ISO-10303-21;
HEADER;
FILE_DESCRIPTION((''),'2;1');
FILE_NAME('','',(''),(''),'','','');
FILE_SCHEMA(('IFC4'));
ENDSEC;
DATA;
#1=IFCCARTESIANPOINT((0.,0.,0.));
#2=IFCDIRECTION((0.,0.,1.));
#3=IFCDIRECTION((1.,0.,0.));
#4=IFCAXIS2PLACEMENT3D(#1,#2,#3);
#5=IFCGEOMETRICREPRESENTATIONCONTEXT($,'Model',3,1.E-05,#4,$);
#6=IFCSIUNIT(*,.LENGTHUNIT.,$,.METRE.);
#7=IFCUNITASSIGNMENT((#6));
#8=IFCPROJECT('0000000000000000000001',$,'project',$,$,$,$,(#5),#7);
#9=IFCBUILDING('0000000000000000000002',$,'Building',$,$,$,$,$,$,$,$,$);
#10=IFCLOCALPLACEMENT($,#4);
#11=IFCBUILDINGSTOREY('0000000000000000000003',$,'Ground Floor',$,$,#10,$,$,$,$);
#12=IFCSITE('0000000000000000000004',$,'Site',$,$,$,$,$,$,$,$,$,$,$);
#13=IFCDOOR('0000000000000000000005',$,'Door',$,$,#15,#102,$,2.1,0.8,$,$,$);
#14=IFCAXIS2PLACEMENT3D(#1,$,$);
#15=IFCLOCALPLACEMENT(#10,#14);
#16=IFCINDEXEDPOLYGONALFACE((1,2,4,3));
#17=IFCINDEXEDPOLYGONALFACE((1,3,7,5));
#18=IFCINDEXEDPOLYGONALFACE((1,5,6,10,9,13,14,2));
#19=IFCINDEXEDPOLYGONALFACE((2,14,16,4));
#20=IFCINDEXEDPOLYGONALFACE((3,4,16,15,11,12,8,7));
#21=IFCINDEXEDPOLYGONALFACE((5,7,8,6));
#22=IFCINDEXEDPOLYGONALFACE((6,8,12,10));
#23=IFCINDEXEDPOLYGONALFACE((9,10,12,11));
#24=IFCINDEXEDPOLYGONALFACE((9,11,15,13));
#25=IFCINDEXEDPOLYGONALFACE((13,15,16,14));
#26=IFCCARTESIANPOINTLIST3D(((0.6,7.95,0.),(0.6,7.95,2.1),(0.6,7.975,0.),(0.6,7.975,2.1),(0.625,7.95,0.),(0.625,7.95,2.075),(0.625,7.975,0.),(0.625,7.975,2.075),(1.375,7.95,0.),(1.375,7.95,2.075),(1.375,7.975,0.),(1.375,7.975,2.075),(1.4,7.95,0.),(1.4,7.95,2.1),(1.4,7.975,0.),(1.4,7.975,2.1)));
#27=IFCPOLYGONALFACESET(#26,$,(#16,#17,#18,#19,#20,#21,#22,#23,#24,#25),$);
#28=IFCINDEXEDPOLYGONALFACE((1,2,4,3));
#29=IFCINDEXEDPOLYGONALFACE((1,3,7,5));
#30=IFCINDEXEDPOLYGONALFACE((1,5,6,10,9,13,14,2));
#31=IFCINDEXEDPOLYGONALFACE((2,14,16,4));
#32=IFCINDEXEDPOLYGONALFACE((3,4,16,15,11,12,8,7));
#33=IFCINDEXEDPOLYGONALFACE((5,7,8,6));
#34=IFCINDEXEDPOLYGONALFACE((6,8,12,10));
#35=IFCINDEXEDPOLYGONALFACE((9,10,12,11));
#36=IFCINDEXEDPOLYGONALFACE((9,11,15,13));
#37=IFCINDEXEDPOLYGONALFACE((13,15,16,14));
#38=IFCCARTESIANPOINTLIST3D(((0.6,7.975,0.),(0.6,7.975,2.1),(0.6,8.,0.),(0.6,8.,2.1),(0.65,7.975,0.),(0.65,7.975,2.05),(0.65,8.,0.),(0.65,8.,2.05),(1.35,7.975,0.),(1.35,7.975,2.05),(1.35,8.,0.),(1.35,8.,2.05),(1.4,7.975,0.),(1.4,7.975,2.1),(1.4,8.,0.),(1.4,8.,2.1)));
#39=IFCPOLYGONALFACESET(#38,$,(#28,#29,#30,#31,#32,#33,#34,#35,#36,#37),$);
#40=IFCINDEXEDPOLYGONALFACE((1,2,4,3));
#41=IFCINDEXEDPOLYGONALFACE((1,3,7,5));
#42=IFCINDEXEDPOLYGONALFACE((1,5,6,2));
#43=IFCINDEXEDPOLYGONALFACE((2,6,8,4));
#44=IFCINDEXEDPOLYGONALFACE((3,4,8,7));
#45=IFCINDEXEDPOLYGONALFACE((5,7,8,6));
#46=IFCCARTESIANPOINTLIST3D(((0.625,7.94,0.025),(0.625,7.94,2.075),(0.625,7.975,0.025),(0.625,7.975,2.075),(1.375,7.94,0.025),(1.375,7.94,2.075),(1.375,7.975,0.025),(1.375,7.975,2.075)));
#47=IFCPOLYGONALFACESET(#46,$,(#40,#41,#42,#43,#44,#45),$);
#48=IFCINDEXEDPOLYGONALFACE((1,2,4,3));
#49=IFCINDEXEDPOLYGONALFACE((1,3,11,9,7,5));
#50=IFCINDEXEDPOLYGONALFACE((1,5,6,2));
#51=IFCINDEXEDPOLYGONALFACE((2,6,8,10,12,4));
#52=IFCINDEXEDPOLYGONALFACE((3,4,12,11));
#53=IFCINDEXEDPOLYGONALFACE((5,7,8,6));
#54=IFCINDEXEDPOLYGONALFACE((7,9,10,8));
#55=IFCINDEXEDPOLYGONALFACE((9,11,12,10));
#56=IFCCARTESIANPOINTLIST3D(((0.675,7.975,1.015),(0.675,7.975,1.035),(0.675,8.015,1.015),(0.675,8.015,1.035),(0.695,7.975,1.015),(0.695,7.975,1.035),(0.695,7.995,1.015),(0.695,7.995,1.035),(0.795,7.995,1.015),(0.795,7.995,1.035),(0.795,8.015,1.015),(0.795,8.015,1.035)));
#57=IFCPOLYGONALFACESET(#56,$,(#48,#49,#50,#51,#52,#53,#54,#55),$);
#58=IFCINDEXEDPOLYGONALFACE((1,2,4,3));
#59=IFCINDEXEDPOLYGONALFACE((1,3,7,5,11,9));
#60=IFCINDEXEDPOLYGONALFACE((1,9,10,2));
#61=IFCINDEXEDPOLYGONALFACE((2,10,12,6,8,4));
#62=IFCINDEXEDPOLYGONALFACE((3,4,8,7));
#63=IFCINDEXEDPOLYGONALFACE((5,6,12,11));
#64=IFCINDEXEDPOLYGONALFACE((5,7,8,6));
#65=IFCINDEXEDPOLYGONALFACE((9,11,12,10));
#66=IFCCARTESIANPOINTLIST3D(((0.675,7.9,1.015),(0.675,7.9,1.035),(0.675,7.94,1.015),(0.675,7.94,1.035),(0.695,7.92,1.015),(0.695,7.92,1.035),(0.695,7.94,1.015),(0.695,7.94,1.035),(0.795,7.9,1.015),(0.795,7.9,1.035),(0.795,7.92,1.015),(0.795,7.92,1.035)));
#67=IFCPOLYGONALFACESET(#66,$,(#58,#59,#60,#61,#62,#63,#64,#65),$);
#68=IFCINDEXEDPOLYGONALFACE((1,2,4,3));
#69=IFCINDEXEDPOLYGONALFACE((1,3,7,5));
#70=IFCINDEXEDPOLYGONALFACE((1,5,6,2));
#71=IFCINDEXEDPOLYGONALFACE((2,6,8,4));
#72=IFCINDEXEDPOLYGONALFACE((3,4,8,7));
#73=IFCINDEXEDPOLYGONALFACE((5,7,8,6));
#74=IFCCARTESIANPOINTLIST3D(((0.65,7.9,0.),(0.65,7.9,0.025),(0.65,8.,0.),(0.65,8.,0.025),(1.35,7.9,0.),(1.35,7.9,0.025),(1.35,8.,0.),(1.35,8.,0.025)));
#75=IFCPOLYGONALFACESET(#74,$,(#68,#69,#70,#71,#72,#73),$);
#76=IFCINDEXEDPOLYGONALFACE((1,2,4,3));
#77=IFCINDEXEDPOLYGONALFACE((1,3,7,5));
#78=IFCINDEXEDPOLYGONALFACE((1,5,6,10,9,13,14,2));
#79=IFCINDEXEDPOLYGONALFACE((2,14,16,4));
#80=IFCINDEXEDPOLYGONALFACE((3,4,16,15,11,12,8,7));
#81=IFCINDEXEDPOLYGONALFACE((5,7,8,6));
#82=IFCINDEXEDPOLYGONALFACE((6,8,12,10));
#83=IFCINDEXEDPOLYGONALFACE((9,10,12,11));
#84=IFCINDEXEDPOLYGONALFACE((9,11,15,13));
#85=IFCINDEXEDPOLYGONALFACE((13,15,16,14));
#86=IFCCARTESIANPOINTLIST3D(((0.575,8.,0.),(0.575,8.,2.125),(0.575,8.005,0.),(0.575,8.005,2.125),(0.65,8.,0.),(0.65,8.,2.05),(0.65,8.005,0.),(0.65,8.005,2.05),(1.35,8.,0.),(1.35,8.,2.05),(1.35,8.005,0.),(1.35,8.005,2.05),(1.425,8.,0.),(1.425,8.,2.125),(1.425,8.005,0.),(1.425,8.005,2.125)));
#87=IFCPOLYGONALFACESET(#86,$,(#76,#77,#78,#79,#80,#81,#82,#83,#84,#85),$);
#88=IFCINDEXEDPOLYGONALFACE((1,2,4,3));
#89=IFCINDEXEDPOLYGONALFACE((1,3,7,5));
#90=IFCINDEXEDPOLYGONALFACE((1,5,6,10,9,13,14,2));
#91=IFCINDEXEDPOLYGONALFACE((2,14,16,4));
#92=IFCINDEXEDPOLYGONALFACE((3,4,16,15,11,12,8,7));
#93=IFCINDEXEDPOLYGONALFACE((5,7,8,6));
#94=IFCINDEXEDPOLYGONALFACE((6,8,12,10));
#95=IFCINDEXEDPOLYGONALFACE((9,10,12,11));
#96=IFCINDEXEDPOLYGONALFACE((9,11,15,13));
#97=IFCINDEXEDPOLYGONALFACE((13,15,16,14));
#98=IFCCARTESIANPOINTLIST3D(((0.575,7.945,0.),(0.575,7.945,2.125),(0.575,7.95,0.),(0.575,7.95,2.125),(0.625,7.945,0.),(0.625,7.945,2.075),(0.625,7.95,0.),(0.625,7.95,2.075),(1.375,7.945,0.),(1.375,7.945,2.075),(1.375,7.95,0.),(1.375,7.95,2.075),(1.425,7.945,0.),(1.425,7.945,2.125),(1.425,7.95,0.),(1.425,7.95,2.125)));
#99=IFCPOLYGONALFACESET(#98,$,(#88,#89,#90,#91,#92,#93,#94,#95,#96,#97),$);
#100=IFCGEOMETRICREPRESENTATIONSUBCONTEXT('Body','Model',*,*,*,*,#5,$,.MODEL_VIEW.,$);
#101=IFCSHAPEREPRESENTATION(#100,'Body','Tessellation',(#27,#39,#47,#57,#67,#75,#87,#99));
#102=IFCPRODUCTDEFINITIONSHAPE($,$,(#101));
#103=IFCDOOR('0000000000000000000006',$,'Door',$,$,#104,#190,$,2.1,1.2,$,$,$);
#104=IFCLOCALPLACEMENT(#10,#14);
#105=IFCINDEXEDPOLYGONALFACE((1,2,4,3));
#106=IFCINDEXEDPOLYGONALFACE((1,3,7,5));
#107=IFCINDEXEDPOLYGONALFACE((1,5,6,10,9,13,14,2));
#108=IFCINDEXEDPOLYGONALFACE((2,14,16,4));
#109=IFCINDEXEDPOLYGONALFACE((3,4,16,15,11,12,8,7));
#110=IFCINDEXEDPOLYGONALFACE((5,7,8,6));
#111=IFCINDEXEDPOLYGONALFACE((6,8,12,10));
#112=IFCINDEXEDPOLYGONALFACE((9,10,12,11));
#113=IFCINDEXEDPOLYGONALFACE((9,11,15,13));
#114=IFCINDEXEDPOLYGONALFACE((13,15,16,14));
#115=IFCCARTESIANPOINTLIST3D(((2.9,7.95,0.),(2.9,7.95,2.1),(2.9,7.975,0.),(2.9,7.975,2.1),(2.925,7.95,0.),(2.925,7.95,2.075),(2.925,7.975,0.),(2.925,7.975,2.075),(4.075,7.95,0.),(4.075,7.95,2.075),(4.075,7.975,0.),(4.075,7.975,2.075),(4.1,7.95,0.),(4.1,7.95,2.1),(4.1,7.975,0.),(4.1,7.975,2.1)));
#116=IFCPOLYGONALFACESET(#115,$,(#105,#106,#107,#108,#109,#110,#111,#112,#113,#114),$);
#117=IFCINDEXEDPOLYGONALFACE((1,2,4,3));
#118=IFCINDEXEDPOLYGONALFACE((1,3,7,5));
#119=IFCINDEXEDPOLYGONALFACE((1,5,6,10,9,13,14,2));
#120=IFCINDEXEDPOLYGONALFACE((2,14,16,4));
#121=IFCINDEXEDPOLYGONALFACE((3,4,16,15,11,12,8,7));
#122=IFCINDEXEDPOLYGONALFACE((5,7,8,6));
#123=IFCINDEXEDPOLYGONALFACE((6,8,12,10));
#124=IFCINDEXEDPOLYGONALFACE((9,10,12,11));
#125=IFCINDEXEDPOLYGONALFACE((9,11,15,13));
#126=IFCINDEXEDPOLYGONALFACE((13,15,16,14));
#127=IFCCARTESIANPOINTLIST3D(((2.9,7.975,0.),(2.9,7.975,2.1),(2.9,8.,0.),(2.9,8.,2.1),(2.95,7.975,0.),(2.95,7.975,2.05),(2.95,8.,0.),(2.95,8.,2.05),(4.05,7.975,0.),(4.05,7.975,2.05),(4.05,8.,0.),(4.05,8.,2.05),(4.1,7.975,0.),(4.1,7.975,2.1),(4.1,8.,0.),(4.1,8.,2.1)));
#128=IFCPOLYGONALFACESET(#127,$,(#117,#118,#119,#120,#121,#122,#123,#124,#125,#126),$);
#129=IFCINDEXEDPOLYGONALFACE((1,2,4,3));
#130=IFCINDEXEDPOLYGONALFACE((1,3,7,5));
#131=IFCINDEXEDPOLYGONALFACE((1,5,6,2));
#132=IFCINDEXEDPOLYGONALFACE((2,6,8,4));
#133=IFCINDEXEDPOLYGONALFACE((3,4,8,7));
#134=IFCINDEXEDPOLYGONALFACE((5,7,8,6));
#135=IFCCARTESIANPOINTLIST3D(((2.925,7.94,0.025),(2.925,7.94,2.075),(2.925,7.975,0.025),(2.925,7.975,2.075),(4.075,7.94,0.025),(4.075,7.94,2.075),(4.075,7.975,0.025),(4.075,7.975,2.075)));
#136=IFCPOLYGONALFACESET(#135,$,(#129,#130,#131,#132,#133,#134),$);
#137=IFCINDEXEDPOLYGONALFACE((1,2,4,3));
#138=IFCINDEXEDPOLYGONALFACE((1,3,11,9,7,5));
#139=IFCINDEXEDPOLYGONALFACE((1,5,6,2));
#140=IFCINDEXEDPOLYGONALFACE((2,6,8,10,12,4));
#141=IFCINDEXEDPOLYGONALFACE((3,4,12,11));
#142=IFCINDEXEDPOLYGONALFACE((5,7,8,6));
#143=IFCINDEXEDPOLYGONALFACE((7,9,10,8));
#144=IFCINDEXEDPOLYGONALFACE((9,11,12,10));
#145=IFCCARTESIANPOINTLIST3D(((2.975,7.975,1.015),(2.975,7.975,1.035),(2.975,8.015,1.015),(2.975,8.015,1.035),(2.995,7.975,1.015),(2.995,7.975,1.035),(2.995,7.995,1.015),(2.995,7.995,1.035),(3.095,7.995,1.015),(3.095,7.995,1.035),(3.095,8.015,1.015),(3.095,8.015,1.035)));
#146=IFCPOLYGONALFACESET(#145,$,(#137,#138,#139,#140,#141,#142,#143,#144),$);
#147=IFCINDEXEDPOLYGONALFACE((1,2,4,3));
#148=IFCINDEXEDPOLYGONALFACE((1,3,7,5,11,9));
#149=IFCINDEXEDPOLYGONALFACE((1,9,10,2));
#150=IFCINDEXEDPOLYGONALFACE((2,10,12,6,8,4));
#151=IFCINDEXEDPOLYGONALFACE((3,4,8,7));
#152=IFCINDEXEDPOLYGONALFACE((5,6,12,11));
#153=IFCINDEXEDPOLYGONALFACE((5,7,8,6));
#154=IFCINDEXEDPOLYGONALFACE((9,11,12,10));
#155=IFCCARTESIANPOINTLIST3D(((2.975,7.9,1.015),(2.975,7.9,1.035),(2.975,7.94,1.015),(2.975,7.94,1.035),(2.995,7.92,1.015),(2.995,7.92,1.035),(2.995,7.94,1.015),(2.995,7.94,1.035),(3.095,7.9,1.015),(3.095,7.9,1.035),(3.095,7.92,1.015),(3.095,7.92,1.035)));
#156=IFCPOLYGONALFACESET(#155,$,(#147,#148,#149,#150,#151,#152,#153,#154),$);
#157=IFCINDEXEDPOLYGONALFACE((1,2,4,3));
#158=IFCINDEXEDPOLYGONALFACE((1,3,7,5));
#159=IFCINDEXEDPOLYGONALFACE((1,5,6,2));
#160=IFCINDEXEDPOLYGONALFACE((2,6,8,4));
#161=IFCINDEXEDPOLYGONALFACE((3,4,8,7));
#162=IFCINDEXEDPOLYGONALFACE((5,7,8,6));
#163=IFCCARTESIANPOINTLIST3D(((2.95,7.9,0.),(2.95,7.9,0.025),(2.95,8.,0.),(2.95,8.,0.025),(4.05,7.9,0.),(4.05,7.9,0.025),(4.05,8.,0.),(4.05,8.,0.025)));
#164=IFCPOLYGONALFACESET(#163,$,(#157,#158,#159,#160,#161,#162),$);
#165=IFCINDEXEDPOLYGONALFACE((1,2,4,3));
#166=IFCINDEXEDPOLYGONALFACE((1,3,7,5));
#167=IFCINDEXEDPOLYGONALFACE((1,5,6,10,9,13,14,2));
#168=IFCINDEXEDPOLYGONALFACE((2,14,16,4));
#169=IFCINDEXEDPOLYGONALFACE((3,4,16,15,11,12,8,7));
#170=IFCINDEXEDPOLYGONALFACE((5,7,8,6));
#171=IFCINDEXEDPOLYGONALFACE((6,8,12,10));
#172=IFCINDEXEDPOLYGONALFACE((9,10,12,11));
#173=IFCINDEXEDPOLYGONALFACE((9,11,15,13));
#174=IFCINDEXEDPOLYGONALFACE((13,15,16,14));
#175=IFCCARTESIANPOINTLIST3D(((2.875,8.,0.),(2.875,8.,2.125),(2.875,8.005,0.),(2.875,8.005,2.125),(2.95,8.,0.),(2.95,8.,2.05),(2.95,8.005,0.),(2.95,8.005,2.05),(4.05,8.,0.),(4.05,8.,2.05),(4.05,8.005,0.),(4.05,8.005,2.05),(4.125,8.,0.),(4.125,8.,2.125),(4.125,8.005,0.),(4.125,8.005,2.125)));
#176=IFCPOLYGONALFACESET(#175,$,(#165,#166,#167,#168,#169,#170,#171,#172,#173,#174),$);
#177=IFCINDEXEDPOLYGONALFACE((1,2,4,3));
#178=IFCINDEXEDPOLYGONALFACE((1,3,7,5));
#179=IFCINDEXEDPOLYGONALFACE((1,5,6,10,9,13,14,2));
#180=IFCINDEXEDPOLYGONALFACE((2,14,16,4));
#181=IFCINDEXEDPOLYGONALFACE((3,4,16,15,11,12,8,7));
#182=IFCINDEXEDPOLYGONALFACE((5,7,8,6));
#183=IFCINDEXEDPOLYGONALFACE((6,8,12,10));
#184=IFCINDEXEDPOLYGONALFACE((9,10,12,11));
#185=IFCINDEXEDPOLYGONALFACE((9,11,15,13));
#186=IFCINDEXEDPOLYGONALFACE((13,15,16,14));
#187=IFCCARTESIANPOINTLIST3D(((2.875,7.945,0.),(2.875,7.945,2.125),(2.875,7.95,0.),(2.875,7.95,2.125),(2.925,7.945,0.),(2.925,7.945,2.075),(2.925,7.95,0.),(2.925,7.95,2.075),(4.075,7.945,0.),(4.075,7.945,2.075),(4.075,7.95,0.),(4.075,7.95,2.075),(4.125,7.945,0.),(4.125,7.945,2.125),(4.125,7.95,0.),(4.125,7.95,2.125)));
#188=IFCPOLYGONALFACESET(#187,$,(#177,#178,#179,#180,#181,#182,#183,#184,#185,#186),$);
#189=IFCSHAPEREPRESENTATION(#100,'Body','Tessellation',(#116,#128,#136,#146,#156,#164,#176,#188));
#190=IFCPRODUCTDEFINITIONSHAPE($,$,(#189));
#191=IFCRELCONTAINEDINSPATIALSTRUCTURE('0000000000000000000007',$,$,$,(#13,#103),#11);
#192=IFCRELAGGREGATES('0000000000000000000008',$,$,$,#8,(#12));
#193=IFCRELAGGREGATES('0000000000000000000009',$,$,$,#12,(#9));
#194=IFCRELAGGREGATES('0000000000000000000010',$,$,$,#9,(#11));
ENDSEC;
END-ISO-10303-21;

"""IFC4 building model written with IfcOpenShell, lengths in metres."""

from ifc_helpers import new_model, si_unit, frame, origin_with_axes, place, context, subcontext, project, spatial, line, indexed_curve, outline, extrude, element, save


model = new_model("IFC4")

# Units and contexts
model_context = context("Model", 3, precision=1e-05, world=origin_with_axes())
body_context = subcontext(model_context, "Body", "Model", "MODEL_VIEW")
ifc_project = project(units=[si_unit("LENGTHUNIT", "METRE")], contexts=[model_context])

# Site, building, storey
site = spatial("IfcSite", under=ifc_project, Name="Site")
building = spatial("IfcBuilding", under=site, Name="Building")
storey_placement = place(None, origin_with_axes())
storey = spatial("IfcBuildingStorey", under=building, at=storey_placement, Name="Ground Floor")

# Doors
door_1_placement = place(storey_placement, frame((1.4, 8.0, 0.0), z_axis=(0.0, 0.0, 1.0), x_axis=(-1.0, 0.0, 0.0)))
element("IfcDoor", 1, at=door_1_placement, inside=storey, Name="Door", OverallHeight=2.1, OverallWidth=0.8, context=body_context, shape_type="SweptSolid", body=[
    extrude(outline(indexed_curve([(0.0, 0.0), (0.0, 2.1), (0.8, 2.1), (0.8, 0.0), (0.775, 0.0), (0.775, 2.075), (0.025, 2.075), (0.025, 0.0)], segments=[line(1, 2, 3, 4, 5, 6, 7, 8, 1)])), frame((0.0, 0.025, 0.0), z_axis=(0.0, -1.0, 0.0), x_axis=(1.0, 0.0, 0.0)), (0.0, 0.0, -1.0), 0.025),
    extrude(outline(indexed_curve([(0.0, 0.0), (0.0, 2.1), (0.8, 2.1), (0.8, 0.0), (0.75, 0.0), (0.75, 2.05), (0.05, 2.05), (0.05, 0.0)], segments=[line(1, 2, 3, 4, 5, 6, 7, 8, 1)])), frame((0.0, 0.0, 0.0), z_axis=(0.0, -1.0, 0.0), x_axis=(1.0, 0.0, 0.0)), (0.0, 0.0, -1.0), 0.025),
    extrude(outline(indexed_curve([(0.0, 0.0), (0.75, 0.0), (0.75, 0.035), (0.0, 0.035)], segments=[line(1, 2, 3, 4, 1)])), frame((0.025, 0.025, 0.025), z_axis=(0.0, 0.0, 1.0), x_axis=(1.0, 0.0, 0.0)), (0.0, 0.0, 1.0), 2.05),
    extrude(outline(indexed_curve([(0.0, 0.0), (0.0, -0.04), (-0.12, -0.04), (-0.12, -0.02), (-0.02, -0.02), (-0.02, 0.0)], segments=[line(1, 2, 3, 4, 5, 6, 1)])), frame((0.725, 0.025, 1.015), z_axis=(0.0, 0.0, 1.0), x_axis=(1.0, 0.0, 0.0)), (0.0, 0.0, 1.0), 0.02),
    extrude(outline(indexed_curve([(0.0, 0.0), (0.0, 0.04), (-0.12, 0.04), (-0.12, 0.02), (-0.02, 0.02), (-0.02, 0.0)], segments=[line(1, 2, 3, 4, 5, 6, 1)])), frame((0.725, 0.06, 1.015), z_axis=(0.0, 0.0, 1.0), x_axis=(1.0, 0.0, 0.0)), (0.0, 0.0, 1.0), 0.02),
    extrude(outline(indexed_curve([(0.0, 0.0), (0.7, 0.0), (0.7, 0.1), (0.0, 0.1)], segments=[line(1, 2, 3, 4, 1)])), frame((0.05, 0.0, 0.0), z_axis=(0.0, 0.0, 1.0), x_axis=(1.0, 0.0, 0.0)), (0.0, 0.0, 1.0), 0.025),
    extrude(outline(indexed_curve([(0.0, 0.0), (0.0, 2.125), (0.85, 2.125), (0.85, 0.0), (0.775, 0.0), (0.775, 2.05), (0.075, 2.05), (0.075, 0.0)], segments=[line(1, 2, 3, 4, 5, 6, 7, 8, 1)])), frame((-0.025, -0.005, 0.0), z_axis=(0.0, -1.0, 0.0), x_axis=(1.0, 0.0, 0.0)), (0.0, 0.0, -1.0), 0.005),
    extrude(outline(indexed_curve([(0.0, 0.0), (0.0, 2.125), (0.85, 2.125), (0.85, 0.0), (0.8, 0.0), (0.8, 2.075), (0.05, 2.075), (0.05, 0.0)], segments=[line(1, 2, 3, 4, 5, 6, 7, 8, 1)])), frame((-0.025, 0.05, 0.0), z_axis=(0.0, -1.0, 0.0), x_axis=(1.0, 0.0, 0.0)), (0.0, 0.0, -1.0), 0.005),
])
door_2_placement = place(storey_placement, frame((4.1, 8.0, 0.0), z_axis=(0.0, 0.0, 1.0), x_axis=(-1.0, 0.0, 0.0)))
element("IfcDoor", 2, at=door_2_placement, inside=storey, Name="Door", OverallHeight=2.1, OverallWidth=1.2, context=body_context, shape_type="SweptSolid", body=[
    extrude(outline(indexed_curve([(0.0, 0.0), (0.0, 2.1), (1.2, 2.1), (1.2, 0.0), (1.175, 0.0), (1.175, 2.075), (0.025, 2.075), (0.025, 0.0)], segments=[line(1, 2, 3, 4, 5, 6, 7, 8, 1)])), frame((0.0, 0.025, 0.0), z_axis=(0.0, -1.0, 0.0), x_axis=(1.0, 0.0, 0.0)), (0.0, 0.0, -1.0), 0.025),
    extrude(outline(indexed_curve([(0.0, 0.0), (0.0, 2.1), (1.2, 2.1), (1.2, 0.0), (1.15, 0.0), (1.15, 2.05), (0.05, 2.05), (0.05, 0.0)], segments=[line(1, 2, 3, 4, 5, 6, 7, 8, 1)])), frame((0.0, 0.0, 0.0), z_axis=(0.0, -1.0, 0.0), x_axis=(1.0, 0.0, 0.0)), (0.0, 0.0, -1.0), 0.025),
    extrude(outline(indexed_curve([(0.0, 0.0), (1.15, 0.0), (1.15, 0.035), (0.0, 0.035)], segments=[line(1, 2, 3, 4, 1)])), frame((0.025, 0.025, 0.025), z_axis=(0.0, 0.0, 1.0), x_axis=(1.0, 0.0, 0.0)), (0.0, 0.0, 1.0), 2.05),
    extrude(outline(indexed_curve([(0.0, 0.0), (0.0, -0.04), (-0.12, -0.04), (-0.12, -0.02), (-0.02, -0.02), (-0.02, 0.0)], segments=[line(1, 2, 3, 4, 5, 6, 1)])), frame((1.125, 0.025, 1.015), z_axis=(0.0, 0.0, 1.0), x_axis=(1.0, 0.0, 0.0)), (0.0, 0.0, 1.0), 0.02),
    extrude(outline(indexed_curve([(0.0, 0.0), (0.0, 0.04), (-0.12, 0.04), (-0.12, 0.02), (-0.02, 0.02), (-0.02, 0.0)], segments=[line(1, 2, 3, 4, 5, 6, 1)])), frame((1.125, 0.06, 1.015), z_axis=(0.0, 0.0, 1.0), x_axis=(1.0, 0.0, 0.0)), (0.0, 0.0, 1.0), 0.02),
    extrude(outline(indexed_curve([(0.0, 0.0), (1.1, 0.0), (1.1, 0.1), (0.0, 0.1)], segments=[line(1, 2, 3, 4, 1)])), frame((0.05, 0.0, 0.0), z_axis=(0.0, 0.0, 1.0), x_axis=(1.0, 0.0, 0.0)), (0.0, 0.0, 1.0), 0.025),
    extrude(outline(indexed_curve([(0.0, 0.0), (0.0, 2.125), (1.25, 2.125), (1.25, 0.0), (1.175, 0.0), (1.175, 2.05), (0.075, 2.05), (0.075, 0.0)], segments=[line(1, 2, 3, 4, 5, 6, 7, 8, 1)])), frame((-0.025, -0.005, 0.0), z_axis=(0.0, -1.0, 0.0), x_axis=(1.0, 0.0, 0.0)), (0.0, 0.0, -1.0), 0.005),
    extrude(outline(indexed_curve([(0.0, 0.0), (0.0, 2.125), (1.25, 2.125), (1.25, 0.0), (1.2, 0.0), (1.2, 2.075), (0.05, 2.075), (0.05, 0.0)], segments=[line(1, 2, 3, 4, 5, 6, 7, 8, 1)])), frame((-0.025, 0.05, 0.0), z_axis=(0.0, -1.0, 0.0), x_axis=(1.0, 0.0, 0.0)), (0.0, 0.0, -1.0), 0.005),
])

save(model, "model.ifc")
